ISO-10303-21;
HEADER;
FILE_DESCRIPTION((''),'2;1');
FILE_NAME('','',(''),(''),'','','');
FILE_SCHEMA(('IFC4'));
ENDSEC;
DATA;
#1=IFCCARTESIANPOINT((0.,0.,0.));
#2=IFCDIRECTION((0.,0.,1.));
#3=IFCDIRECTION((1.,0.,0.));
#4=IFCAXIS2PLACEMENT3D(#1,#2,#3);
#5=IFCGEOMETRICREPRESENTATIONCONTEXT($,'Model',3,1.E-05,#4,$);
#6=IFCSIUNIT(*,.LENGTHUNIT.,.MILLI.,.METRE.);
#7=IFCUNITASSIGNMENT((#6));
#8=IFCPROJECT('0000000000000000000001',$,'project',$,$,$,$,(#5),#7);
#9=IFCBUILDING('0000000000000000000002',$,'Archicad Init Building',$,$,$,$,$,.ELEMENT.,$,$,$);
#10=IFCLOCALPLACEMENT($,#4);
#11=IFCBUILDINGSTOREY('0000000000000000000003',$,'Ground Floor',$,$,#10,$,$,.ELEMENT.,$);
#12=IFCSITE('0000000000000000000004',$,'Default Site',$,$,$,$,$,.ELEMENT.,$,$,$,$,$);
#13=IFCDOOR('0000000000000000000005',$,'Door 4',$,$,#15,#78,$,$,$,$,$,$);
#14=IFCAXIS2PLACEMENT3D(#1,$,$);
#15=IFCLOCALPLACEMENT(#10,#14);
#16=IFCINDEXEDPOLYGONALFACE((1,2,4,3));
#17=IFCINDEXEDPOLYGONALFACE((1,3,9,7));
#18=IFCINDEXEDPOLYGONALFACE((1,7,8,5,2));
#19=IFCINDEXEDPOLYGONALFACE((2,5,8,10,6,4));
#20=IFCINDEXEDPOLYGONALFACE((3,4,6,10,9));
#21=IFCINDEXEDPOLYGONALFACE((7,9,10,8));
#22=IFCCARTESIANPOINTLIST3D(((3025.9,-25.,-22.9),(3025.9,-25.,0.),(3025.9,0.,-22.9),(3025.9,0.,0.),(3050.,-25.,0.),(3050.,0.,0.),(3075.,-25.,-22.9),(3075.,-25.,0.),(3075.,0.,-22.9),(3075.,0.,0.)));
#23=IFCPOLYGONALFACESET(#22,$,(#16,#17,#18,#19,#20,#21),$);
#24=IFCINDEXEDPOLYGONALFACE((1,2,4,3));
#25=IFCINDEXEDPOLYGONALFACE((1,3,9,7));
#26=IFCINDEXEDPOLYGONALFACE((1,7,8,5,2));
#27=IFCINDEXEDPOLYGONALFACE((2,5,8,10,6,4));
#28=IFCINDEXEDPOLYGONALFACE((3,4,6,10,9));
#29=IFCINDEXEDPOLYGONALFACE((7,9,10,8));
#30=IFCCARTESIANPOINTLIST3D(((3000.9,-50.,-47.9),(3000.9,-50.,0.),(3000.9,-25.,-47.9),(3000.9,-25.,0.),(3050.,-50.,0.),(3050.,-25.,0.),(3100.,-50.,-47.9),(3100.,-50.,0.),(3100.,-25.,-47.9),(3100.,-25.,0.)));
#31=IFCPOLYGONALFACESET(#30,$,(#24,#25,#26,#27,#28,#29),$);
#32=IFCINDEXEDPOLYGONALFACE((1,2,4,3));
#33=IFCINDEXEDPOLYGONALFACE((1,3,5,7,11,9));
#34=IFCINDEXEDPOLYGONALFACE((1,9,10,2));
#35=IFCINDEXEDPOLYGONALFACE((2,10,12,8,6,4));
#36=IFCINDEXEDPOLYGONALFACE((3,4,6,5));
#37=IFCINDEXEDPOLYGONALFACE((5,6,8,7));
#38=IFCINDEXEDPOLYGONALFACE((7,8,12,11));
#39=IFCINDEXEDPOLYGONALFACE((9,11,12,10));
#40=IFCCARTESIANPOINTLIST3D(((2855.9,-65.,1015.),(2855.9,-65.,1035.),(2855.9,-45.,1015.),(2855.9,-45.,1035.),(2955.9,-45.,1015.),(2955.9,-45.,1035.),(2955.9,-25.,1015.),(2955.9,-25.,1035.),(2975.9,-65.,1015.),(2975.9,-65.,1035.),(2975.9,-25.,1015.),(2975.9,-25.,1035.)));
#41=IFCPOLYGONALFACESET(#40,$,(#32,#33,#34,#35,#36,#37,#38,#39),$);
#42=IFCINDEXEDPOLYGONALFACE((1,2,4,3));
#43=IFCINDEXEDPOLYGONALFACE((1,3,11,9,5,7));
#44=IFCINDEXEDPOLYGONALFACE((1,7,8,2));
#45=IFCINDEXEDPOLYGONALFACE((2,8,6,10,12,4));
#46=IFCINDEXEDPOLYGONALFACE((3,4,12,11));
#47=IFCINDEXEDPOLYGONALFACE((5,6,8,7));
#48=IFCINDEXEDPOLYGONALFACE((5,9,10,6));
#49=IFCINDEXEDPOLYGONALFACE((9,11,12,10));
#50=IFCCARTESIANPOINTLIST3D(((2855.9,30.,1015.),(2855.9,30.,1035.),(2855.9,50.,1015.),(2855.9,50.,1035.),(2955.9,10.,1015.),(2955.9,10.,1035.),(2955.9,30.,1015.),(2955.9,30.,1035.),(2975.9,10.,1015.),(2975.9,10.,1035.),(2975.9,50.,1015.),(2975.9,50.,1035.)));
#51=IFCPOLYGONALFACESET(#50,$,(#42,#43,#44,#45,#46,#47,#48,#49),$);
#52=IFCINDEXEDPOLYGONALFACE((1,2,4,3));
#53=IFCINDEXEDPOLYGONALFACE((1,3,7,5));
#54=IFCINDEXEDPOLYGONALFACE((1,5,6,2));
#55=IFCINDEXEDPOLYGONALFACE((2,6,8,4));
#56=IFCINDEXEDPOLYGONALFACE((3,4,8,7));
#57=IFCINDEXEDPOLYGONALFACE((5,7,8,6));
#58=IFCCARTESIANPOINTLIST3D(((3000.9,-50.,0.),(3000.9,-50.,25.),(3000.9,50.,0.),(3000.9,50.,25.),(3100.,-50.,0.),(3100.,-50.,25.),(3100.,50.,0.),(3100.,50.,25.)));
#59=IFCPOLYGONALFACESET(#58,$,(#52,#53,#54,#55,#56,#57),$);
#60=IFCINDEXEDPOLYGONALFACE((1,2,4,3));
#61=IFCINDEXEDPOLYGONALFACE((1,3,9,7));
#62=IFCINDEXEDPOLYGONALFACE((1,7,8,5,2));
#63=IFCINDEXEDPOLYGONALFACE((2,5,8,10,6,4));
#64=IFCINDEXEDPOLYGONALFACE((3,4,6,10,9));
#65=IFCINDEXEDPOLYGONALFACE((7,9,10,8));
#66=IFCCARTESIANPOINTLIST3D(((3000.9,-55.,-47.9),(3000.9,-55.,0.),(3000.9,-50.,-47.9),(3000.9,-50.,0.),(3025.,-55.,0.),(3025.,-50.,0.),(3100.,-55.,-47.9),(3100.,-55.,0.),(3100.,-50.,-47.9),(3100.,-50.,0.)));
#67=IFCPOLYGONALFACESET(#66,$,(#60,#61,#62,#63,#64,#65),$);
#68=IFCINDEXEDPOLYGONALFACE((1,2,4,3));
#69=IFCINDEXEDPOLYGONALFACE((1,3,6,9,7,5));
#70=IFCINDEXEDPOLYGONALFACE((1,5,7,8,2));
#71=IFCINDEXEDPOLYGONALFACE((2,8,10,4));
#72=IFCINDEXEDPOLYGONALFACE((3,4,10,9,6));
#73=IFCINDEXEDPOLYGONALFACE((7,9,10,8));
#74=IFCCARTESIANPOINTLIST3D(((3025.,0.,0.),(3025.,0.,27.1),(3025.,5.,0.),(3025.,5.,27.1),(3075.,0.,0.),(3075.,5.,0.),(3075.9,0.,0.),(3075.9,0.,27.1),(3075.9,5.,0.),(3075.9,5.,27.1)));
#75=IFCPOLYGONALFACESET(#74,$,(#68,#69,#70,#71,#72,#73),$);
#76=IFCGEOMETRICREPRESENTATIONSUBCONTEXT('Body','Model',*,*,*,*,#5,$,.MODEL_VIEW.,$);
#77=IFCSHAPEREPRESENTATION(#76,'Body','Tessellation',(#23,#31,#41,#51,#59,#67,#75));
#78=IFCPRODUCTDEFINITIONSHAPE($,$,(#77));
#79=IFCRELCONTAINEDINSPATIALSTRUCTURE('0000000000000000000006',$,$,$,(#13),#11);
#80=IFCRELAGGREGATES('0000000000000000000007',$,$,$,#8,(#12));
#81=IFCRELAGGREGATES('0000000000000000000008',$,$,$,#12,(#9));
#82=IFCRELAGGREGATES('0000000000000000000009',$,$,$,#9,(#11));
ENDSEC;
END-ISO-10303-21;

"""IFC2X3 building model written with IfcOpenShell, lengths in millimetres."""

from ifc_helpers import new_model, si_unit, frame, origin_with_axes, place, context, subcontext, project, spatial, polyline, outline, extrude, element, save


model = new_model("IFC2X3")

# Units and contexts
model_context = context("Model", 3, precision=1e-05, world=origin_with_axes())
body_context = subcontext(model_context, "Body", "Model", "MODEL_VIEW")
ifc_project = project(units=[si_unit("LENGTHUNIT", "METRE", prefix="MILLI")], contexts=[model_context])

# Site, building, storey
site = spatial("IfcSite", under=ifc_project, Name="Default Site", CompositionType="ELEMENT")
building = spatial("IfcBuilding", under=site, Name="Archicad Init Building", CompositionType="ELEMENT")
storey_placement = place(None, origin_with_axes())
storey = spatial("IfcBuildingStorey", under=building, at=storey_placement, Name="Ground Floor", CompositionType="ELEMENT")

# Door
door_1_placement = place(storey_placement, frame((3050.0, -50.0, 0.0), z_axis=(0.0, 0.0, 1.0), x_axis=(1.0, 0.0, 0.0)))
element("IfcDoor", 1, at=door_1_placement, inside=storey, Name="Door 4", context=body_context, shape_type="SweptSolid", body=[
    extrude(outline(polyline([(0.0, 0.0), (0.0, 2.1), (0.9, 2.1), (0.9, 0.0), (-24.1, 0.0), (-24.1, -22.9), (25.0, -22.9), (25.0, 0.0), (0.0, 0.0)])), frame((0.0, 25.0, 0.0), z_axis=(0.0, -1.0, 0.0), x_axis=(1.0, 0.0, 0.0)), (0.0, 0.0, -1.0), 25.0),
    extrude(outline(polyline([(0.0, 0.0), (0.0, 2.1), (0.9, 2.1), (0.9, 0.0), (-49.1, 0.0), (-49.1, -47.9), (50.0, -47.9), (50.0, 0.0), (0.0, 0.0)])), frame((0.0, 0.0, 0.0), z_axis=(0.0, -1.0, 0.0), x_axis=(1.0, 0.0, 0.0)), (0.0, 0.0, -1.0), 25.0),
    extrude(outline(polyline([(0.0, 0.0), (-49.1, 0.0), (-49.1, 35.0), (0.0, 35.0), (0.0, 0.0)])), frame((25.0, 25.0, 25.0), z_axis=(0.0, 0.0, 1.0), x_axis=(1.0, 0.0, 0.0)), (0.0, 0.0, 1.0), -47.9),
    extrude(outline(polyline([(0.0, 0.0), (0.0, -40.0), (-120.0, -40.0), (-120.0, -20.0), (-20.0, -20.0), (-20.0, 0.0), (0.0, 0.0)])), frame((-74.1, 25.0, 1015.0), z_axis=(0.0, 0.0, 1.0), x_axis=(1.0, 0.0, 0.0)), (0.0, 0.0, 1.0), 20.0),
    extrude(outline(polyline([(0.0, 0.0), (0.0, 40.0), (-120.0, 40.0), (-120.0, 20.0), (-20.0, 20.0), (-20.0, 0.0), (0.0, 0.0)])), frame((-74.1, 60.0, 1015.0), z_axis=(0.0, 0.0, 1.0), x_axis=(1.0, 0.0, 0.0)), (0.0, 0.0, 1.0), 20.0),
    extrude(outline(polyline([(0.0, 0.0), (-99.1, 0.0), (-99.1, 100.0), (0.0, 100.0), (0.0, 0.0)])), frame((50.0, 0.0, 0.0), z_axis=(0.0, 0.0, 1.0), x_axis=(1.0, 0.0, 0.0)), (0.0, 0.0, 1.0), 25.0),
    extrude(outline(polyline([(0.0, 0.0), (0.0, 27.1), (50.9, 27.1), (50.9, 0.0), (-24.1, 0.0), (-24.1, -47.9), (75.0, -47.9), (75.0, 0.0), (0.0, 0.0)])), frame((-25.0, -5.0, 0.0), z_axis=(0.0, -1.0, 0.0), x_axis=(1.0, 0.0, 0.0)), (0.0, 0.0, -1.0), 5.0),
    extrude(outline(polyline([(0.0, 0.0), (0.0, 27.1), (50.9, 27.1), (50.9, 0.0), (0.9, 0.0), (0.9, -22.9), (50.0, -22.9), (50.0, 0.0), (0.0, 0.0)])), frame((-25.0, 50.0, 0.0), z_axis=(0.0, -1.0, 0.0), x_axis=(1.0, 0.0, 0.0)), (0.0, 0.0, -1.0), 5.0),
])

save(model, "model.ifc")
